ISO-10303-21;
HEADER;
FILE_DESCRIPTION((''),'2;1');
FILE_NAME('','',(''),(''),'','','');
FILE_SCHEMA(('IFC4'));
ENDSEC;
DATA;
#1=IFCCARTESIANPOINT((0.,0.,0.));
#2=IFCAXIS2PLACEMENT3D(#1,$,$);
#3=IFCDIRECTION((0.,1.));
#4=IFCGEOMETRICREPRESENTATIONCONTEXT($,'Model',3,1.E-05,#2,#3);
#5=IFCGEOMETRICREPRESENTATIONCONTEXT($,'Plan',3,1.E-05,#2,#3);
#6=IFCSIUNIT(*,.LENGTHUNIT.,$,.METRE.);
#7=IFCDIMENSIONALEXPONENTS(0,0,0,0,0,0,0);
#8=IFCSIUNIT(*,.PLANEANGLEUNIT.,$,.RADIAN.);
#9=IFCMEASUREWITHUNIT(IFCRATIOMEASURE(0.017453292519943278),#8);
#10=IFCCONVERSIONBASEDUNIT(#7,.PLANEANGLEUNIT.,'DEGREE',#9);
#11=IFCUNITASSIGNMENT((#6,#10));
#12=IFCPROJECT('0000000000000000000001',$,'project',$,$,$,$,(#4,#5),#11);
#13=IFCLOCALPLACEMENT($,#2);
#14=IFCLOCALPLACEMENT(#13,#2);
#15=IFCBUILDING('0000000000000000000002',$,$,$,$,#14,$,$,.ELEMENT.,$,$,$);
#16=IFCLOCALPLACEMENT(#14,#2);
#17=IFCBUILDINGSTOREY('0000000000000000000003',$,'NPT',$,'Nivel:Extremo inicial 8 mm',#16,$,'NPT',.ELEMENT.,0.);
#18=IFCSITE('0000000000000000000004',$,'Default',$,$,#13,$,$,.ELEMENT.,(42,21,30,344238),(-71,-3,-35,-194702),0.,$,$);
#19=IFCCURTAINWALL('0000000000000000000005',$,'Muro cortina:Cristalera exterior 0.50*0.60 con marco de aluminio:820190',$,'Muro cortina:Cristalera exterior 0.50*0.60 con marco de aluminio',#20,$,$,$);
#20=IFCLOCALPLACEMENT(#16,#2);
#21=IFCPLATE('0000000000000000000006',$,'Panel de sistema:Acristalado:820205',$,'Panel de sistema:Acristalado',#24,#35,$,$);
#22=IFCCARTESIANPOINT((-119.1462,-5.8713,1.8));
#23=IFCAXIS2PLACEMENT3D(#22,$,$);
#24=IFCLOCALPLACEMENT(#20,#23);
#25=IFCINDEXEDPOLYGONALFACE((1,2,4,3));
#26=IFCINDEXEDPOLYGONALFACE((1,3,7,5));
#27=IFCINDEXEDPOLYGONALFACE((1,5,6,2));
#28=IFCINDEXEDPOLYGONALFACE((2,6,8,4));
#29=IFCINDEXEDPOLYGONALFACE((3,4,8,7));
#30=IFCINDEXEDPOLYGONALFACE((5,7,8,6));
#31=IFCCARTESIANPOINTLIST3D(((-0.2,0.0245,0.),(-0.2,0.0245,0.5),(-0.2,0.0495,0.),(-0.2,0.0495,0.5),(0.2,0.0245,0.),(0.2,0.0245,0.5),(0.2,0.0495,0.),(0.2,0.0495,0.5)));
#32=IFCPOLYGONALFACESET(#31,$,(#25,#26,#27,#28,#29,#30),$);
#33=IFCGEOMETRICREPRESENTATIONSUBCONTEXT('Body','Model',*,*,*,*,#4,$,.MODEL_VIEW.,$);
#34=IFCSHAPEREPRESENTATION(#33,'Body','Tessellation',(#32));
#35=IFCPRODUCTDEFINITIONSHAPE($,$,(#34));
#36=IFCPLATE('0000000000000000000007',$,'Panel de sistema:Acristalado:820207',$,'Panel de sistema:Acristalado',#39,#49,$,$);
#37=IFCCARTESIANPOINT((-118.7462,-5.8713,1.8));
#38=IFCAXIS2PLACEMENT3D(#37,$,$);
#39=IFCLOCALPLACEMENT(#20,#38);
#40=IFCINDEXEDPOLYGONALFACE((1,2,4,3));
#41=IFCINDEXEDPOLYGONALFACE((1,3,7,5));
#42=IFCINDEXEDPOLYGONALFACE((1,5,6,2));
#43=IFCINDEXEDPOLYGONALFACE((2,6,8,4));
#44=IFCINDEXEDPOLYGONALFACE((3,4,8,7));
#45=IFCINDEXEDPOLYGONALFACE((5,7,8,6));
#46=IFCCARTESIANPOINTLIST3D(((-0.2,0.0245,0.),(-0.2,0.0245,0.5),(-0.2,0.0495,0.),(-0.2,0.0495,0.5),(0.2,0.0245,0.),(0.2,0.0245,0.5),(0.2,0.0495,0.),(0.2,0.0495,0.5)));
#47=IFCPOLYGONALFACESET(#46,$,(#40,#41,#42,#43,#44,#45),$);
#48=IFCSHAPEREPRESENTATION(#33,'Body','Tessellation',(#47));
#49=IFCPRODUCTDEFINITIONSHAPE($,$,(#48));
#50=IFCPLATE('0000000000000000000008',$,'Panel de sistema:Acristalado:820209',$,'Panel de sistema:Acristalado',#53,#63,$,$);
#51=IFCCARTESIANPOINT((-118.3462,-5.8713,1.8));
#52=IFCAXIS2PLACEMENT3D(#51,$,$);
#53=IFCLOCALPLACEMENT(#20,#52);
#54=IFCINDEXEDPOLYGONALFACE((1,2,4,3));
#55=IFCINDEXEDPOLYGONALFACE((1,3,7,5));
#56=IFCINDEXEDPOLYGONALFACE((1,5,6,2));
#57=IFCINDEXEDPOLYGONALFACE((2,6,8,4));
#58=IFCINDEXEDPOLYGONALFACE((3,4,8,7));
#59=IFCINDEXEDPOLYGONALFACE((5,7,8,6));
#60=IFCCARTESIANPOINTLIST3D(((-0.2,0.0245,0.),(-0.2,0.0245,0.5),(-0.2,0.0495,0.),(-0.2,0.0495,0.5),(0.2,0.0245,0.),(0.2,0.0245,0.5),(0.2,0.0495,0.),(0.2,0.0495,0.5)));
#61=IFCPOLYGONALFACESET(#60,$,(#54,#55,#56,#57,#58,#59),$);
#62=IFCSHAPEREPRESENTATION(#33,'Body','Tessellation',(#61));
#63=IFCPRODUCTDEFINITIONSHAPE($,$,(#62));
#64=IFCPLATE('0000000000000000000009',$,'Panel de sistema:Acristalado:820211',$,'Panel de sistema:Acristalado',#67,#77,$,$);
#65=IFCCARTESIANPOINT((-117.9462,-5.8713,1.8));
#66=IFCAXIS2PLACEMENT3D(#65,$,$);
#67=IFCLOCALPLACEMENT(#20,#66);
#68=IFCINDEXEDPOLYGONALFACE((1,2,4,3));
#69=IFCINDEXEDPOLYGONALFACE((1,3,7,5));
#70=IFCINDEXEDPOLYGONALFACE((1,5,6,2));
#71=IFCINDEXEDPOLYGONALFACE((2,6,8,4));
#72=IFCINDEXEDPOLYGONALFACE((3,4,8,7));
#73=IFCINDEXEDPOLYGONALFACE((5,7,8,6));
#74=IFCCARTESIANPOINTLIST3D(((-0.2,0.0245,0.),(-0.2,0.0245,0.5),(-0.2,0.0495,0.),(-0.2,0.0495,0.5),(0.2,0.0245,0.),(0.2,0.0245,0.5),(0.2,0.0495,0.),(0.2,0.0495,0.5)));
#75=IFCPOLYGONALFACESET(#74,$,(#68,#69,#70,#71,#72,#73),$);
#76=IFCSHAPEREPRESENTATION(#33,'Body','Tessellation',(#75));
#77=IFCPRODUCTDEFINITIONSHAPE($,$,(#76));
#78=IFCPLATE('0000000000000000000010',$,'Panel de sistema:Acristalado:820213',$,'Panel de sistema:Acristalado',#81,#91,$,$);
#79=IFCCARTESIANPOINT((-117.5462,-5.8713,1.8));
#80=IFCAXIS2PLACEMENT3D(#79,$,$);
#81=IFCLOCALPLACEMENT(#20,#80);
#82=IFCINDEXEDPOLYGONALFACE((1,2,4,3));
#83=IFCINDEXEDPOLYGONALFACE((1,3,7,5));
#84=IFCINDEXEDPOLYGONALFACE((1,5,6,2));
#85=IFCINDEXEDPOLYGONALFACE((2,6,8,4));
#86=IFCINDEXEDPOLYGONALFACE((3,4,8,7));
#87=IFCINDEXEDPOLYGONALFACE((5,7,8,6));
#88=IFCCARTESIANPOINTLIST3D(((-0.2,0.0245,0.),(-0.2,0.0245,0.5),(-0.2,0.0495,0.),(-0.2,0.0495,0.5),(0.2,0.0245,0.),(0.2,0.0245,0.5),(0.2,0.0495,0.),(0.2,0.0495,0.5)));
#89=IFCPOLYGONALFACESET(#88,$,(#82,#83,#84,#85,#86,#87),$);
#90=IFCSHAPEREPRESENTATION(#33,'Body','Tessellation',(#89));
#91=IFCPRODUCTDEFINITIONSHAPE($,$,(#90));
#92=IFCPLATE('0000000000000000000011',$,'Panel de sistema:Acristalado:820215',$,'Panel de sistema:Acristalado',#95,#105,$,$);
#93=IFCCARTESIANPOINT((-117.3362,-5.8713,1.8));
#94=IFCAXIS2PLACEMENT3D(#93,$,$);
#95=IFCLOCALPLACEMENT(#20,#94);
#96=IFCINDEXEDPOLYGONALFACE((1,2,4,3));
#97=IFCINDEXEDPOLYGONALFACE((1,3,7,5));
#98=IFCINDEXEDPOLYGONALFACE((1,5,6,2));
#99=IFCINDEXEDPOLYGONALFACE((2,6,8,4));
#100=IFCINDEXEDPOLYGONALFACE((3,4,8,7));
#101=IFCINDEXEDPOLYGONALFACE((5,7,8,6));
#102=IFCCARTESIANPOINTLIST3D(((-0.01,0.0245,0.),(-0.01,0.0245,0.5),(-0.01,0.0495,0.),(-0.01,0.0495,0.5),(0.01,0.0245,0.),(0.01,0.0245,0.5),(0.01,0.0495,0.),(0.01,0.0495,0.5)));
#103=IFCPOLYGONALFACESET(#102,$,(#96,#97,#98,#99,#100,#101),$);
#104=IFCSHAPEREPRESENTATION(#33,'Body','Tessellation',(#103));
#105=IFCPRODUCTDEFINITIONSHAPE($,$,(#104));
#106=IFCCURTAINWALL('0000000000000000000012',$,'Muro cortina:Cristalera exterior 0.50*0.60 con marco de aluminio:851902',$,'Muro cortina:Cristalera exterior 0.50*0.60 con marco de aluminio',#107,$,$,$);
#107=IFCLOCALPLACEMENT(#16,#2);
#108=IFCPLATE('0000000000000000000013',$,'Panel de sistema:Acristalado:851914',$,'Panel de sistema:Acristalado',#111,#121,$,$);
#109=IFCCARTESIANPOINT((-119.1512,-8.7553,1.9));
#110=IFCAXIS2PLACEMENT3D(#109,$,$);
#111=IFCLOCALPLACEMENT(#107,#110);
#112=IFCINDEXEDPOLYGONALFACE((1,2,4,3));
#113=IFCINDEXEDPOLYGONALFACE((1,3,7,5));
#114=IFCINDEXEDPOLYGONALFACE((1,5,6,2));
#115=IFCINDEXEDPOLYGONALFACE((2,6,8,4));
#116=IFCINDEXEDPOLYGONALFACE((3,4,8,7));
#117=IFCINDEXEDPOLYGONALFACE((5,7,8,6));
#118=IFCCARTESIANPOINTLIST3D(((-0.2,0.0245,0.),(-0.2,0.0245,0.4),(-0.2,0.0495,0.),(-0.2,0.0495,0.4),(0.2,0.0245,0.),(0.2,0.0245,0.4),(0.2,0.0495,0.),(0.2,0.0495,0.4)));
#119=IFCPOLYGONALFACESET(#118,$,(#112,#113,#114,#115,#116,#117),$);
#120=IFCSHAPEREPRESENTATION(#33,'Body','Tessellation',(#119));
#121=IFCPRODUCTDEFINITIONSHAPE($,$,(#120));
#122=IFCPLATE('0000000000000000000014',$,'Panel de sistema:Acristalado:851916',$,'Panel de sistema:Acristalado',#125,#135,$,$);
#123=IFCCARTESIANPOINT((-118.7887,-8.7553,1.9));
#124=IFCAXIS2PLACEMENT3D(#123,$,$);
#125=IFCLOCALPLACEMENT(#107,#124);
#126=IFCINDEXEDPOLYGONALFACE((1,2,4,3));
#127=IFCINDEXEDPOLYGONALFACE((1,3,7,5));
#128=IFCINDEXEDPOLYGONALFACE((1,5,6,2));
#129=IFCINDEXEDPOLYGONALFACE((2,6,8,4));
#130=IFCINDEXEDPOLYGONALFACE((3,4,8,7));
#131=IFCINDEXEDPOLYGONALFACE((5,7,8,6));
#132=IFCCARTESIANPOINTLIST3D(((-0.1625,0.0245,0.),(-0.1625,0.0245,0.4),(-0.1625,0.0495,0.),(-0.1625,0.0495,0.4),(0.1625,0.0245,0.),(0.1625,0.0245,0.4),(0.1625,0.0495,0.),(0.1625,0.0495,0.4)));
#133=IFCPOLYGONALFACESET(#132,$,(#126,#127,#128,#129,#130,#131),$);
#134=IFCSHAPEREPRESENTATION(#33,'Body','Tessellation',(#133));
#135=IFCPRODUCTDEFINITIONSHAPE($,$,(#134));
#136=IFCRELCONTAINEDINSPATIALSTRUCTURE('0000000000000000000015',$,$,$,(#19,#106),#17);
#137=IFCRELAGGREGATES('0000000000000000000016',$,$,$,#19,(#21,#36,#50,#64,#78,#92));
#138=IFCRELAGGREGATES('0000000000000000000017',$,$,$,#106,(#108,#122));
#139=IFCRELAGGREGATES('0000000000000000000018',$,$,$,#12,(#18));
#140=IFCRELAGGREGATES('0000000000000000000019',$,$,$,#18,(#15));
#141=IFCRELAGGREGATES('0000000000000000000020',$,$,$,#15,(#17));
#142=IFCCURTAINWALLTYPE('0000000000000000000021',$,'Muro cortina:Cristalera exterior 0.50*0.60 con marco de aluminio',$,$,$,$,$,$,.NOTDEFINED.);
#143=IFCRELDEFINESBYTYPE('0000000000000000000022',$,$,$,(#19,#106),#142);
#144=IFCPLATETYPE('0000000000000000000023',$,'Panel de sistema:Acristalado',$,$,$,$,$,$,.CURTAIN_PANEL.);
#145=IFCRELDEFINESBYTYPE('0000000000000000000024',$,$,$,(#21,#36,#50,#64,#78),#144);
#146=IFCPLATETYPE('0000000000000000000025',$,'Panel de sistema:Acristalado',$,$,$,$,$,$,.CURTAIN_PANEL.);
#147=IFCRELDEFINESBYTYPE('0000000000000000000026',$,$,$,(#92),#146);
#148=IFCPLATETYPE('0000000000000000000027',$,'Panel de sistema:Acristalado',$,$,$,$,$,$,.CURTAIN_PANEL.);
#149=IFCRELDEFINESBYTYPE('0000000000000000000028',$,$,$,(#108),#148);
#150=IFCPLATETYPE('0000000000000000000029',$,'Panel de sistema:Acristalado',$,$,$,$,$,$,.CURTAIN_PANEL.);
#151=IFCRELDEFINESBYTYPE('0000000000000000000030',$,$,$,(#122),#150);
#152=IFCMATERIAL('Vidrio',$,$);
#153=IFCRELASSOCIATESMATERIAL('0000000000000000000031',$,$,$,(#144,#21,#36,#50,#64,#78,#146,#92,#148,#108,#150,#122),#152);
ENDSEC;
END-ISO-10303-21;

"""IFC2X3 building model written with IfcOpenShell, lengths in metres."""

from ifc_helpers import new_model, entity, si_unit, converted_unit, direction, frame, origin, origin_2d_with_axis, place, context, subcontext, project, spatial, rectangle, extrude, source, transform, mapped, material, type_object, type_shapes, element, aggregate, save


model = new_model("IFC2X3")

# Units and contexts
model_context = context("Model", 3, precision=1e-05, world=origin(), true_north=direction((0.0, 1.0)))
plan_context = context("Plan", 3, precision=1e-05, world=origin(), true_north=direction((0.0, 1.0)))
body_context = subcontext(model_context, "Body", "Model", "MODEL_VIEW")
ifc_project = project(units=[si_unit("LENGTHUNIT", "METRE"), converted_unit("PLANEANGLEUNIT", "DEGREE", entity("IfcRatioMeasure", 0.017453292519943278), si_unit("PLANEANGLEUNIT", "RADIAN"), dimensions=[0, 0, 0, 0, 0, 0, 0])], contexts=[model_context, plan_context])

# Site, building, storey
site_placement = place(None, origin())
site = spatial("IfcSite", under=ifc_project, at=site_placement, Name="Default", CompositionType="ELEMENT", RefLatitude=(42, 21, 30, 344238), RefLongitude=(-71, -3, -35, -194702), RefElevation=0.0)
building_placement = place(site_placement, origin())
building = spatial("IfcBuilding", under=site, at=building_placement, CompositionType="ELEMENT")
storey_placement = place(building_placement, origin())
storey = spatial("IfcBuildingStorey", under=building, at=storey_placement, Name="NPT", ObjectType="Nivel:Extremo inicial 8 mm", LongName="NPT", CompositionType="ELEMENT", Elevation=0.0)

# Curtain walls, plates
curtain_wall_type = type_object("IfcCurtainWallType", Name="Muro cortina:Cristalera exterior 0.50*0.60 con marco de aluminio", PredefinedType="NOTDEFINED")
curtain_wall_1_placement = place(storey_placement, origin())
curtain_wall_1 = element("IfcCurtainWall", 1, at=curtain_wall_1_placement, inside=storey, type_object=curtain_wall_type, Name="Muro cortina:Cristalera exterior 0.50*0.60 con marco de aluminio:820190", ObjectType="Muro cortina:Cristalera exterior 0.50*0.60 con marco de aluminio")
ifc_material_1 = material(Name="Vidrio")
plate_type_1 = type_object("IfcPlateType", Name="Panel de sistema:Acristalado", PredefinedType="CURTAIN_PANEL", material=ifc_material_1)
shared_shape_1 = source(origin(), body_context, "Body", "SweptSolid", [
    extrude(rectangle(XDim=0.025, YDim=0.4, at=origin_2d_with_axis()), frame((0.0, 0.037, 0.0), z_axis=(0.0, 0.0, 1.0), x_axis=(0.0, 1.0, 0.0)), (0.0, 0.0, 1.0), 0.5),
])
type_shapes(plate_type_1, [shared_shape_1])
plate_1_placement = place(curtain_wall_1_placement, frame((-119.1462, -5.8713, 1.8)))
plate_1 = element("IfcPlate", 2, at=plate_1_placement, type_object=plate_type_1, material=ifc_material_1, Name="Panel de sistema:Acristalado:820205", ObjectType="Panel de sistema:Acristalado", context=body_context, shape_type="MappedRepresentation", body=[
    mapped(shared_shape_1, transform((0.0, 0.0, 0.0), scale=1.0)),
])
plate_2_placement = place(curtain_wall_1_placement, frame((-118.7462, -5.8713, 1.8)))
plate_2 = element("IfcPlate", 3, at=plate_2_placement, type_object=plate_type_1, material=ifc_material_1, Name="Panel de sistema:Acristalado:820207", ObjectType="Panel de sistema:Acristalado", context=body_context, shape_type="MappedRepresentation", body=[
    mapped(shared_shape_1, transform((0.0, 0.0, 0.0), scale=1.0)),
])
plate_3_placement = place(curtain_wall_1_placement, frame((-118.3462, -5.8713, 1.8)))
plate_3 = element("IfcPlate", 4, at=plate_3_placement, type_object=plate_type_1, material=ifc_material_1, Name="Panel de sistema:Acristalado:820209", ObjectType="Panel de sistema:Acristalado", context=body_context, shape_type="MappedRepresentation", body=[
    mapped(shared_shape_1, transform((0.0, 0.0, 0.0), scale=1.0)),
])
plate_4_placement = place(curtain_wall_1_placement, frame((-117.9462, -5.8713, 1.8)))
plate_4 = element("IfcPlate", 5, at=plate_4_placement, type_object=plate_type_1, material=ifc_material_1, Name="Panel de sistema:Acristalado:820211", ObjectType="Panel de sistema:Acristalado", context=body_context, shape_type="MappedRepresentation", body=[
    mapped(shared_shape_1, transform((0.0, 0.0, 0.0), scale=1.0)),
])
plate_5_placement = place(curtain_wall_1_placement, frame((-117.5462, -5.8713, 1.8)))
plate_5 = element("IfcPlate", 6, at=plate_5_placement, type_object=plate_type_1, material=ifc_material_1, Name="Panel de sistema:Acristalado:820213", ObjectType="Panel de sistema:Acristalado", context=body_context, shape_type="MappedRepresentation", body=[
    mapped(shared_shape_1, transform((0.0, 0.0, 0.0), scale=1.0)),
])
plate_type_2 = type_object("IfcPlateType", Name="Panel de sistema:Acristalado", PredefinedType="CURTAIN_PANEL", material=ifc_material_1)
shared_shape_2 = source(origin(), body_context, "Body", "SweptSolid", [
    extrude(rectangle(XDim=0.025, YDim=0.02, at=origin_2d_with_axis()), frame((0.0, 0.037, 0.0), z_axis=(0.0, 0.0, 1.0), x_axis=(0.0, 1.0, 0.0)), (0.0, 0.0, 1.0), 0.5),
])
type_shapes(plate_type_2, [shared_shape_2])
plate_6_placement = place(curtain_wall_1_placement, frame((-117.3362, -5.8713, 1.8)))
plate_6 = element("IfcPlate", 7, at=plate_6_placement, type_object=plate_type_2, material=ifc_material_1, Name="Panel de sistema:Acristalado:820215", ObjectType="Panel de sistema:Acristalado", context=body_context, shape_type="MappedRepresentation", body=[
    mapped(shared_shape_2, transform((0.0, 0.0, 0.0), scale=1.0)),
])
aggregate(curtain_wall_1, [plate_1, plate_2, plate_3, plate_4, plate_5, plate_6])
curtain_wall_2_placement = place(storey_placement, origin())
curtain_wall_2 = element("IfcCurtainWall", 8, at=curtain_wall_2_placement, inside=storey, type_object=curtain_wall_type, Name="Muro cortina:Cristalera exterior 0.50*0.60 con marco de aluminio:851902", ObjectType="Muro cortina:Cristalera exterior 0.50*0.60 con marco de aluminio")
plate_type_3 = type_object("IfcPlateType", Name="Panel de sistema:Acristalado", PredefinedType="CURTAIN_PANEL", material=ifc_material_1)
shared_shape_3 = source(origin(), body_context, "Body", "SweptSolid", [
    extrude(rectangle(XDim=0.025, YDim=0.4, at=origin_2d_with_axis()), frame((0.0, 0.037, 0.0), z_axis=(0.0, 0.0, 1.0), x_axis=(0.0, 1.0, 0.0)), (0.0, 0.0, 1.0), 0.4),
])
type_shapes(plate_type_3, [shared_shape_3])
plate_7_placement = place(curtain_wall_2_placement, frame((-119.1512, -8.7553, 1.9)))
plate_7 = element("IfcPlate", 9, at=plate_7_placement, type_object=plate_type_3, material=ifc_material_1, Name="Panel de sistema:Acristalado:851914", ObjectType="Panel de sistema:Acristalado", context=body_context, shape_type="MappedRepresentation", body=[
    mapped(shared_shape_3, transform((0.0, 0.0, 0.0), scale=1.0)),
])
plate_type_4 = type_object("IfcPlateType", Name="Panel de sistema:Acristalado", PredefinedType="CURTAIN_PANEL", material=ifc_material_1)
shared_shape_4 = source(origin(), body_context, "Body", "SweptSolid", [
    extrude(rectangle(XDim=0.025, YDim=0.325, at=origin_2d_with_axis()), frame((0.0, 0.037, 0.0), z_axis=(0.0, 0.0, 1.0), x_axis=(0.0, 1.0, 0.0)), (0.0, 0.0, 1.0), 0.4),
])
type_shapes(plate_type_4, [shared_shape_4])
plate_8_placement = place(curtain_wall_2_placement, frame((-118.7887, -8.7553, 1.9)))
plate_8 = element("IfcPlate", 10, at=plate_8_placement, type_object=plate_type_4, material=ifc_material_1, Name="Panel de sistema:Acristalado:851916", ObjectType="Panel de sistema:Acristalado", context=body_context, shape_type="MappedRepresentation", body=[
    mapped(shared_shape_4, transform((0.0, 0.0, 0.0), scale=1.0)),
])
aggregate(curtain_wall_2, [plate_7, plate_8])

save(model, "model.ifc")
